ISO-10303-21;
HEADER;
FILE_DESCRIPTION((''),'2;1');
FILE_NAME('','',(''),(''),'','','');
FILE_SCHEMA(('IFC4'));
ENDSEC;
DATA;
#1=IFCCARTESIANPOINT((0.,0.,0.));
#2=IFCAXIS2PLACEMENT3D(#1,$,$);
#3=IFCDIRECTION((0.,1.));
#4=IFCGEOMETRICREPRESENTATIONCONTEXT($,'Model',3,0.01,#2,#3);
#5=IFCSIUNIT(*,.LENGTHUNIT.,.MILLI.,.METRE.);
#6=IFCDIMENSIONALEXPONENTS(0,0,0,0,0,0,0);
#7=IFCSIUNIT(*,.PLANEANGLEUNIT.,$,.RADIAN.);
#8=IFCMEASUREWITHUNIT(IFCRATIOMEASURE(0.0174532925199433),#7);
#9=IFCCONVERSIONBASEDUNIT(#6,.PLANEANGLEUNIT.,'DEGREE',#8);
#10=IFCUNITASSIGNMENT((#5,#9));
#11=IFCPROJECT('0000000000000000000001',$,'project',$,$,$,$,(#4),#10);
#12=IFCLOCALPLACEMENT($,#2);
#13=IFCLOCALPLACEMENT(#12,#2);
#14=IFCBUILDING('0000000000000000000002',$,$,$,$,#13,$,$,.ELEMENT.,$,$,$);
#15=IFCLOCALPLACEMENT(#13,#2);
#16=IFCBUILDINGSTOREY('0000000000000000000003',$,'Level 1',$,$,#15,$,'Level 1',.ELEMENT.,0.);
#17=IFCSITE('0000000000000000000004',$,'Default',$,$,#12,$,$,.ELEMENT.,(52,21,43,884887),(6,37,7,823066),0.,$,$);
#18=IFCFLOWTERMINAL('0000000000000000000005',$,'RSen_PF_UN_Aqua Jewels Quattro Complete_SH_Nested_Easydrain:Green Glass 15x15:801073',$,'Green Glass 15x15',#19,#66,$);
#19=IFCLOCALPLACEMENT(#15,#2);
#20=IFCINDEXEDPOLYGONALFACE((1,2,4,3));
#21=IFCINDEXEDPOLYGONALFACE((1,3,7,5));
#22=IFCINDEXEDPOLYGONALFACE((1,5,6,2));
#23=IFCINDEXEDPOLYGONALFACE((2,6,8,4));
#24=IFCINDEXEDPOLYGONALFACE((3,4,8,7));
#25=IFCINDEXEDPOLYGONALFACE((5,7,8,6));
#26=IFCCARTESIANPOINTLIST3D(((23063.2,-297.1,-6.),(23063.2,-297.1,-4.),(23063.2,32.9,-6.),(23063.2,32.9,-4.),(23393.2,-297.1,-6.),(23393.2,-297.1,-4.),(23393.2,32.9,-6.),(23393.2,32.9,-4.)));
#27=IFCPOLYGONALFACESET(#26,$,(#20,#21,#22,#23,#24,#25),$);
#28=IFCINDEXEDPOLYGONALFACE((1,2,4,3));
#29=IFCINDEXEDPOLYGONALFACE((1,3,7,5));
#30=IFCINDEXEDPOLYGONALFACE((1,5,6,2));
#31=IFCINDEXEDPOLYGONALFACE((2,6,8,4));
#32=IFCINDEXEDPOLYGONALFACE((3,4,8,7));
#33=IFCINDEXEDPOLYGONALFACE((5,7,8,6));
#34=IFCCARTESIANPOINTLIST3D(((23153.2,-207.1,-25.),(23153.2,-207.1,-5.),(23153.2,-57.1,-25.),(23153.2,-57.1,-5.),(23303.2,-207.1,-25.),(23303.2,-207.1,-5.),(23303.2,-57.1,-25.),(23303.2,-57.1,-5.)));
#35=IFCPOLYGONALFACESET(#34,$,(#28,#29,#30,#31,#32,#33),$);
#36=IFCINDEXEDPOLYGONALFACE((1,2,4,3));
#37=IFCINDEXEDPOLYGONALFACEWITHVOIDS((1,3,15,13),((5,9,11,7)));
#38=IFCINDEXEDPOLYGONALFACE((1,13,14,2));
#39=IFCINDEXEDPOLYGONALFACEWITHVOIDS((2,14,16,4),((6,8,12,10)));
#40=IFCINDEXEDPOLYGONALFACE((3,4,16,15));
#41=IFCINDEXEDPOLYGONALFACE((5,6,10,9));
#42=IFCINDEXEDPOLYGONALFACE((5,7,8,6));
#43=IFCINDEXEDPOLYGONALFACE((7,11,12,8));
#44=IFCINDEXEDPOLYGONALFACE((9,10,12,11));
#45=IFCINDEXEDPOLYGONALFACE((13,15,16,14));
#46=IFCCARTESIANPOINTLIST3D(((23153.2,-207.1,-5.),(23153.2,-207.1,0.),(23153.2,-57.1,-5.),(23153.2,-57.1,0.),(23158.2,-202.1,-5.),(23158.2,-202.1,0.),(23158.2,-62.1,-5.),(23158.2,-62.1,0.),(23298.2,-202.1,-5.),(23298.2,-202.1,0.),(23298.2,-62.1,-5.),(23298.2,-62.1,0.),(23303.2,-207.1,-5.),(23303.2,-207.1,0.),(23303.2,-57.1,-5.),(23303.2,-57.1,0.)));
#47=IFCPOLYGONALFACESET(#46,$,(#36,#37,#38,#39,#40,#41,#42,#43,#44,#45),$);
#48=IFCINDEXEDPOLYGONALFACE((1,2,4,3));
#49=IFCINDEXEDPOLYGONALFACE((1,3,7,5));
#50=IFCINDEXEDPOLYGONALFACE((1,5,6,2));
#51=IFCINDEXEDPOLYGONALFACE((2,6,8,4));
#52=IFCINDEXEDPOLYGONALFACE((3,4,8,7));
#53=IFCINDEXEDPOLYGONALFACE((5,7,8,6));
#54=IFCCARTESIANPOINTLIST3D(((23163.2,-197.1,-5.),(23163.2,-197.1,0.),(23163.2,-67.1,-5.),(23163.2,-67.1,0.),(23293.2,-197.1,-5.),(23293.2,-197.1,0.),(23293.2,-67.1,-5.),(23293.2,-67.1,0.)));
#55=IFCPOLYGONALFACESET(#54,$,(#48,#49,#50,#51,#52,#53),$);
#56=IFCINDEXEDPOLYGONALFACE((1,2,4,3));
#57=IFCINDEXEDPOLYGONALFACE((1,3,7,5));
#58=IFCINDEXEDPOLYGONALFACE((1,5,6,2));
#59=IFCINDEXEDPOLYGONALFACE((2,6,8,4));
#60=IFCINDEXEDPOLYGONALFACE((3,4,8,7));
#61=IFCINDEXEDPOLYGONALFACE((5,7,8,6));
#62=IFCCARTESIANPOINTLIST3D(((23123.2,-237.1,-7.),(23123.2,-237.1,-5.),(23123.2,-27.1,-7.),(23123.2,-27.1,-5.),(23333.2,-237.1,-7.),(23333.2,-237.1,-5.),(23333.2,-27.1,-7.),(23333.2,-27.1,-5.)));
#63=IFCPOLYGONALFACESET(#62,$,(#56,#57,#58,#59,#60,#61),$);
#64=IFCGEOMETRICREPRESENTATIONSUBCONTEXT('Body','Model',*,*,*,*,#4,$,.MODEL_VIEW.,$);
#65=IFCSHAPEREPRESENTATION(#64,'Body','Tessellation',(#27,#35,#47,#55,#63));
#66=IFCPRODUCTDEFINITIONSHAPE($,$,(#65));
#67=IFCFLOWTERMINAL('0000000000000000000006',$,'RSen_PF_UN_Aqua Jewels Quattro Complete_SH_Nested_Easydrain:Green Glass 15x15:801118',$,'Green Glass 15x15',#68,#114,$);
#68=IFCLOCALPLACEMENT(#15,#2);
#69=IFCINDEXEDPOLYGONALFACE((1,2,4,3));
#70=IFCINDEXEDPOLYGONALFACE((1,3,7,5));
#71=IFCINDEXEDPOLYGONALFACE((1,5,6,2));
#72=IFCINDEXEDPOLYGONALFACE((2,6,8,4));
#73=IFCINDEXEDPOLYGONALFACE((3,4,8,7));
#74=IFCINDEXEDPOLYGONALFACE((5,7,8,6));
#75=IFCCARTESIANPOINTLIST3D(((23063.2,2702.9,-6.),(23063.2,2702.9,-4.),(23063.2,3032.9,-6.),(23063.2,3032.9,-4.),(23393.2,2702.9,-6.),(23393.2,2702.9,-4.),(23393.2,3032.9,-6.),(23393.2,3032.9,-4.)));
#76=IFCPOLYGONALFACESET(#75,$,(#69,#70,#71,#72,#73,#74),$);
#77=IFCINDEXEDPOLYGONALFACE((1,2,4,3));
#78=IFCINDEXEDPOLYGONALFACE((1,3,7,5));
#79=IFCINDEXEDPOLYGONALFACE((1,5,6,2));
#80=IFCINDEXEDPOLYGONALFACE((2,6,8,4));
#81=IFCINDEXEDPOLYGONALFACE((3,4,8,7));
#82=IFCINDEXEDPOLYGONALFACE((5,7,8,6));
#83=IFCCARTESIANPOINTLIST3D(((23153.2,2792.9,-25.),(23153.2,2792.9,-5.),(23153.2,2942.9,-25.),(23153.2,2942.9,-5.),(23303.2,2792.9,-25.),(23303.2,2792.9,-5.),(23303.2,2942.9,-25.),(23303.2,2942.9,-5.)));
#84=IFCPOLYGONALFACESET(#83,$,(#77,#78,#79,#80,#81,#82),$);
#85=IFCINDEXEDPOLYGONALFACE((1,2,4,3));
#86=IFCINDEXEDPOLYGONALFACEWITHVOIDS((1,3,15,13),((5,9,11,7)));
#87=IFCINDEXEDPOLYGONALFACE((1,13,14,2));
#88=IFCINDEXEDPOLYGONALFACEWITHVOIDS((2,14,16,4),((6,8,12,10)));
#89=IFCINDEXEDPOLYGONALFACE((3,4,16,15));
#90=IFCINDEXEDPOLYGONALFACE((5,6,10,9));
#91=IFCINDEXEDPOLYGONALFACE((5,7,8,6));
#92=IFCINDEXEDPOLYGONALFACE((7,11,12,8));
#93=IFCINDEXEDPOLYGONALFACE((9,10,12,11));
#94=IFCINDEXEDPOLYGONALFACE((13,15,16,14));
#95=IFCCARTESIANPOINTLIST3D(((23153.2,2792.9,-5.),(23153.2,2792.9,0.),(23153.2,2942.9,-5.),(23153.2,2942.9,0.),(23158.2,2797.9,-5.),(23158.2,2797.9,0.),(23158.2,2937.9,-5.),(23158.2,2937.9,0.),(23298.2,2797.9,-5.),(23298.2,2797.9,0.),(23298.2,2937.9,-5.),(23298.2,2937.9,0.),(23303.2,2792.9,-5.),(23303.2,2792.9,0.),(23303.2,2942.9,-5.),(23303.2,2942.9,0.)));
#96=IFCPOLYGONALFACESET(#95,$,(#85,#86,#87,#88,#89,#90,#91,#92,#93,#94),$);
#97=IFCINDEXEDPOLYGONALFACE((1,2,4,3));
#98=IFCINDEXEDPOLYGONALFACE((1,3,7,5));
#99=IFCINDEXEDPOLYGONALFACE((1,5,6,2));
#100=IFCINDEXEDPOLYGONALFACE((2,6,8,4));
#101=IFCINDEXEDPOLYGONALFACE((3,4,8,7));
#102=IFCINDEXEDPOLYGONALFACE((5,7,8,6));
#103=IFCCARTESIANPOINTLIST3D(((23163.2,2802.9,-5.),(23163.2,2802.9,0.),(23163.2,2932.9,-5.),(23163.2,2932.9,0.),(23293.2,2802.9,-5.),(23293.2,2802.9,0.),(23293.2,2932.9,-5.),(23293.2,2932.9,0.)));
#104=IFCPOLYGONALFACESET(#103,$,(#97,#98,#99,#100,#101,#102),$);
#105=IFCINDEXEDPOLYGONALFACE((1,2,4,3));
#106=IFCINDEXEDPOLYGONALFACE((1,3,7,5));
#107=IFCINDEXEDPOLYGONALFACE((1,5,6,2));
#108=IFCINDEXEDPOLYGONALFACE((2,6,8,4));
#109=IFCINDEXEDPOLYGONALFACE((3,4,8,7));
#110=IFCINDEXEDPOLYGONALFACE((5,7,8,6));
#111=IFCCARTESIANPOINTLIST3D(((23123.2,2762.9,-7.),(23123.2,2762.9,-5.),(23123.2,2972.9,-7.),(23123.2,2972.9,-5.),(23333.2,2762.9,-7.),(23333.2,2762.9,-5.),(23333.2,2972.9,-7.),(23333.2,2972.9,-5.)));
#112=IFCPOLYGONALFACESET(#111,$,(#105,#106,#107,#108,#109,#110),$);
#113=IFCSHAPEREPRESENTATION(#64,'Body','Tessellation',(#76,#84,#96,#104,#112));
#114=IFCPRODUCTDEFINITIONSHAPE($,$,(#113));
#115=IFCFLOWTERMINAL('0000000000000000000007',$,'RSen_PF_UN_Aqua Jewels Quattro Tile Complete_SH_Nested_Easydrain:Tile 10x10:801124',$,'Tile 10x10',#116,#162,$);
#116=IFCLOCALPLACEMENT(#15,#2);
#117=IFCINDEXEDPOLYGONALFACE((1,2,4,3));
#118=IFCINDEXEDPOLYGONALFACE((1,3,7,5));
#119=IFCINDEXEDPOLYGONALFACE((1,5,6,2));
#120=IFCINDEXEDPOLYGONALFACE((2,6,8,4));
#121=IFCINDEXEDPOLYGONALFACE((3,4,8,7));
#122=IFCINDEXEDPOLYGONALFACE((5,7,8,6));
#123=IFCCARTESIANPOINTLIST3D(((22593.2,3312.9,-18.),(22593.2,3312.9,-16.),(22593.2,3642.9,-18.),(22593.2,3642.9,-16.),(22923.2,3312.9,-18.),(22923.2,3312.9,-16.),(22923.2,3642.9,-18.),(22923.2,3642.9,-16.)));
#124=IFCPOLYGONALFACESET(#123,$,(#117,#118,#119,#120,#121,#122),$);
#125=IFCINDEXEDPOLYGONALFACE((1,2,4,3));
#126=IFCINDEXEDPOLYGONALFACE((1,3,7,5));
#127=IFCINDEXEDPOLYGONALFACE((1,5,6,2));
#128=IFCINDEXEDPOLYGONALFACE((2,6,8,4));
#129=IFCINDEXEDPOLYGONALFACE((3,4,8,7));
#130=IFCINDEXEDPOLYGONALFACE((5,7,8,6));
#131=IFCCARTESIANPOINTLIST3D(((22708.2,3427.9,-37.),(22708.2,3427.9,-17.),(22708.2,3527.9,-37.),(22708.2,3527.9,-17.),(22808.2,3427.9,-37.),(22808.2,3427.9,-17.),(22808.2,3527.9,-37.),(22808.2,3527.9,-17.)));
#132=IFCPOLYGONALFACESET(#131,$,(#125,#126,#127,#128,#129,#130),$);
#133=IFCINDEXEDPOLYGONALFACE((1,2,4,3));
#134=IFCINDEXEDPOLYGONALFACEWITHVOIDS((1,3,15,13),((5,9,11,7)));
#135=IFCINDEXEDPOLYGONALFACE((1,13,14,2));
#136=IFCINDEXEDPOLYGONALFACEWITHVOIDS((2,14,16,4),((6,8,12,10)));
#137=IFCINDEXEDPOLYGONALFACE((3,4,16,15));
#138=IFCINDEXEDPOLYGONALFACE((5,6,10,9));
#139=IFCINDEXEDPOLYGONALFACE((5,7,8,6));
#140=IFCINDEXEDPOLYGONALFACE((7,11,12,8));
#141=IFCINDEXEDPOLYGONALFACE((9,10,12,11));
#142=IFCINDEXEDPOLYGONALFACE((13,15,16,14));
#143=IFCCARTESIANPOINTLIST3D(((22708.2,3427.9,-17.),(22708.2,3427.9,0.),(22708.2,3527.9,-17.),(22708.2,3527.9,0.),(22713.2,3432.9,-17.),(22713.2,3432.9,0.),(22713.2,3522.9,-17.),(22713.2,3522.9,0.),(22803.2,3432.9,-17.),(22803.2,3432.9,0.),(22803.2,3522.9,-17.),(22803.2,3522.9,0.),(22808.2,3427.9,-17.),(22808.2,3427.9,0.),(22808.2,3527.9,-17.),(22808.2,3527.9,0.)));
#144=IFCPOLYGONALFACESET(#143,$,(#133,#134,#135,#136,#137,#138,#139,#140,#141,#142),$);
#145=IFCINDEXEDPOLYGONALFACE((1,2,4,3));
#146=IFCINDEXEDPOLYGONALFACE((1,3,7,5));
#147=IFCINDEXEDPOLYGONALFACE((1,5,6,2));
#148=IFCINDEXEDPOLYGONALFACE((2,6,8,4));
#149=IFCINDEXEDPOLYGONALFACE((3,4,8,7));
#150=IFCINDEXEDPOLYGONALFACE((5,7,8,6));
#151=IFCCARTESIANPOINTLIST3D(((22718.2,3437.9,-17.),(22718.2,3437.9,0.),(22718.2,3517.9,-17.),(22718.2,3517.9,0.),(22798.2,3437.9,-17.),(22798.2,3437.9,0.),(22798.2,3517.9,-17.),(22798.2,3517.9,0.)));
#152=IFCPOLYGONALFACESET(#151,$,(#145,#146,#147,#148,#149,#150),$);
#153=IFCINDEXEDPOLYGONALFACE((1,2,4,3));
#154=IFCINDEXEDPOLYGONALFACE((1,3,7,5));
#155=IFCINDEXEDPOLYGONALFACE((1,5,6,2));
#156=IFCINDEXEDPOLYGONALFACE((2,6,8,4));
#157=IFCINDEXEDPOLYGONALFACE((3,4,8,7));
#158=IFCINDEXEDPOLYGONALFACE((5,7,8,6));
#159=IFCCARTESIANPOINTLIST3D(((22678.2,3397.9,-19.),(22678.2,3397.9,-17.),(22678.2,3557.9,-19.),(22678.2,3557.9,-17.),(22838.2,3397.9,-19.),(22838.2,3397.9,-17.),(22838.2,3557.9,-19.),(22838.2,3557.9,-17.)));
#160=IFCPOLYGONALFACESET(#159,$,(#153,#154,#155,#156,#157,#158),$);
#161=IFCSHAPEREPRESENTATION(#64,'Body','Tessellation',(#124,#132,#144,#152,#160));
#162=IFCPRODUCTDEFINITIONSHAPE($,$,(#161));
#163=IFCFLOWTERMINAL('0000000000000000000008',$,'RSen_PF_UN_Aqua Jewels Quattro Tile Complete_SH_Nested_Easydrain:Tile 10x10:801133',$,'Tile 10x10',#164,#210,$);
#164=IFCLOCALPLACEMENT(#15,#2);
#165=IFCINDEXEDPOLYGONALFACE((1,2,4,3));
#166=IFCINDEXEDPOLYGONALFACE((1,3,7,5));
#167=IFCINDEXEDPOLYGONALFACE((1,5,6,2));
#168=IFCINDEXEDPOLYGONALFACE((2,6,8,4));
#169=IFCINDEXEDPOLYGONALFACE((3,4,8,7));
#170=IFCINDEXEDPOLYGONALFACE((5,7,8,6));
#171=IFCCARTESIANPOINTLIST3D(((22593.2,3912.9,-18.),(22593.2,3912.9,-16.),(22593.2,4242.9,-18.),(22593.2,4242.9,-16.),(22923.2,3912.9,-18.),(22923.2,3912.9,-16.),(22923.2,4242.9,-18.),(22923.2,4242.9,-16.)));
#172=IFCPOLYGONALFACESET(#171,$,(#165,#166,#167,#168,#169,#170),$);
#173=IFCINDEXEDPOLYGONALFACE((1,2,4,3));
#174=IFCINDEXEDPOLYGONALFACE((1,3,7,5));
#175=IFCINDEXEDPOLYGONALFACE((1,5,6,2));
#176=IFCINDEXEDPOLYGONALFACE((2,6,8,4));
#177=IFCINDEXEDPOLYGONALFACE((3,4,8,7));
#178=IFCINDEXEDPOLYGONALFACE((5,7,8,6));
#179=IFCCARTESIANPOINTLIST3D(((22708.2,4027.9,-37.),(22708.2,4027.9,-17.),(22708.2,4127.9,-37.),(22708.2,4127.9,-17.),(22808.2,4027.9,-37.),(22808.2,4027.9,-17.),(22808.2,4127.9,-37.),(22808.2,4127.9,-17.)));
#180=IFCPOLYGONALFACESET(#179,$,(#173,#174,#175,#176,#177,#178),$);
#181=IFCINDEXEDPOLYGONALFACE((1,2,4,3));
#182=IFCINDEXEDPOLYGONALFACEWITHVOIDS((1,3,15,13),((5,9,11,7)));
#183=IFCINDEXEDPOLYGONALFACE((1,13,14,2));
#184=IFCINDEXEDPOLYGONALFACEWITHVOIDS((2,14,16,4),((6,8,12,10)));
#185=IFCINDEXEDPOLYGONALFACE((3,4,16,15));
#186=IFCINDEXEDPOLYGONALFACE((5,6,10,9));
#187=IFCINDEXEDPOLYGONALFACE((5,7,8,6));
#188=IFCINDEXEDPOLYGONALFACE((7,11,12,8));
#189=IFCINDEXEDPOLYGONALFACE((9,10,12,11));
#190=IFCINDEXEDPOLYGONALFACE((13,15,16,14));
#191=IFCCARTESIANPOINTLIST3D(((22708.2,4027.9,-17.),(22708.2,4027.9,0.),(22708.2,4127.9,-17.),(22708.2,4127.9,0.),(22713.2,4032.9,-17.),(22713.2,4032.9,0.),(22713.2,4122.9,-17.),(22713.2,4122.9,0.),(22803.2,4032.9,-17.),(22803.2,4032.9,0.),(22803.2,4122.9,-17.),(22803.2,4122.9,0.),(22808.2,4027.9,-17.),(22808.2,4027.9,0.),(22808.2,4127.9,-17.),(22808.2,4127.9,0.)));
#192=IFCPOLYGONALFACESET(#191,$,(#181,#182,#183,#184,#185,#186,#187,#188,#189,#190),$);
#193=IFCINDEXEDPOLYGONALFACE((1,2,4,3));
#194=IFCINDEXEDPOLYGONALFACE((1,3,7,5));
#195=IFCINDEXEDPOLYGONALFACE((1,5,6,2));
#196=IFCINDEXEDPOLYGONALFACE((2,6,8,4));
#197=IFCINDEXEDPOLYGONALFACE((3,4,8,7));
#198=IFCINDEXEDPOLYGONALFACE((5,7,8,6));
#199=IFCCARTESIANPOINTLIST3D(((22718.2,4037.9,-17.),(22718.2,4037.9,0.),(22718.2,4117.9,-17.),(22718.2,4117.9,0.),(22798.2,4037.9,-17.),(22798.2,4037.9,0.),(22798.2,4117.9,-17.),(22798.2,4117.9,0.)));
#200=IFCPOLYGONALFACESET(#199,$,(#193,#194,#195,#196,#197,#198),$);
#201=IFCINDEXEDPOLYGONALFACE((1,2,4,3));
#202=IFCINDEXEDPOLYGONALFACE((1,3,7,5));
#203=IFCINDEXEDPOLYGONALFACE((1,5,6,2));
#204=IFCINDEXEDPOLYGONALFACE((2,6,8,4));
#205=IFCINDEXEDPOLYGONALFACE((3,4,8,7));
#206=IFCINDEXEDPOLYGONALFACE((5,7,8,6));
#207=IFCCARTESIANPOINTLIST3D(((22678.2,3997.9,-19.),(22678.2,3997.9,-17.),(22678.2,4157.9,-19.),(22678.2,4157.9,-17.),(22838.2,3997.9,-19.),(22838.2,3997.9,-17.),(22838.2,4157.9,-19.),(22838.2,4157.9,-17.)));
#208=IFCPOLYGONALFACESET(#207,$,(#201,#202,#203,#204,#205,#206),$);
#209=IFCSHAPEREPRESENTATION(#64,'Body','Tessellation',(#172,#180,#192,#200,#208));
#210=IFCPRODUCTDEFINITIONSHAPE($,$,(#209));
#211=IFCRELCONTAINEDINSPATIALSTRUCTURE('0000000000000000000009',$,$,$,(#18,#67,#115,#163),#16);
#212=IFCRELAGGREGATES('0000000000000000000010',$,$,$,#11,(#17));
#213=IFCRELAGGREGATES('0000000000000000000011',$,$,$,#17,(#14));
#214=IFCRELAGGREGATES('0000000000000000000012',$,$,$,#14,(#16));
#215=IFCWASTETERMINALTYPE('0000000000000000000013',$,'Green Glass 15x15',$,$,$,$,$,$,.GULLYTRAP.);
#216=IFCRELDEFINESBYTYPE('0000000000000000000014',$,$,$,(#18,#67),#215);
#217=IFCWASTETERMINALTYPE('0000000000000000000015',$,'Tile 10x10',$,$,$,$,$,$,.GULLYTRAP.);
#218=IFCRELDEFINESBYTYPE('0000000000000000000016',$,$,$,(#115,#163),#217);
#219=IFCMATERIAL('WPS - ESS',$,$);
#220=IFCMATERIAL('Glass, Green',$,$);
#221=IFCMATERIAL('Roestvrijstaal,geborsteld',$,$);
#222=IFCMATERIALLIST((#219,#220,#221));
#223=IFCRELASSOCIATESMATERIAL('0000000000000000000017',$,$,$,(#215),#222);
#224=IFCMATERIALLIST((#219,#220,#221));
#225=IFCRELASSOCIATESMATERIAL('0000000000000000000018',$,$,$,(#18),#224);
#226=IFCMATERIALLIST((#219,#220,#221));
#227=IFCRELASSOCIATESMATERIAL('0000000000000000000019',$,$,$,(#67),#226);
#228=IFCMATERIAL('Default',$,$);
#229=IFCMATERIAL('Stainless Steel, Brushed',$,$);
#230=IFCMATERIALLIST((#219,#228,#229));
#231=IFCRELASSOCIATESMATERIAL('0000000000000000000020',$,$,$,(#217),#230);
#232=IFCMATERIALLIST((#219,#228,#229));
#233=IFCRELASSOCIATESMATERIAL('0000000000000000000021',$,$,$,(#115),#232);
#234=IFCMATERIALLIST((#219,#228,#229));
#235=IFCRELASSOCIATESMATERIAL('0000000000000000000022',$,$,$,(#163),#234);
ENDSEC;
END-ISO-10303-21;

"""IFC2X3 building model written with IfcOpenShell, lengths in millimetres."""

from ifc_helpers import new_model, entity, si_unit, converted_unit, direction, frame, frame_2d, origin, origin_2d_with_axis, place, context, subcontext, project, spatial, polyline, rectangle, outline, extrude, source, transform, mapped, material, material_list, type_object, type_shapes, element, save


model = new_model("IFC2X3")

# Units and contexts
model_context = context("Model", 3, precision=0.01, world=origin(), true_north=direction((0.0, 1.0)))
body_context = subcontext(model_context, "Body", "Model", "MODEL_VIEW")
ifc_project = project(units=[si_unit("LENGTHUNIT", "METRE", prefix="MILLI"), converted_unit("PLANEANGLEUNIT", "DEGREE", entity("IfcRatioMeasure", 0.0174532925199433), si_unit("PLANEANGLEUNIT", "RADIAN"), dimensions=[0, 0, 0, 0, 0, 0, 0])], contexts=[model_context])

# Site, building, storey
site_placement = place(None, origin())
site = spatial("IfcSite", under=ifc_project, at=site_placement, Name="Default", CompositionType="ELEMENT", RefLatitude=(52, 21, 43, 884887), RefLongitude=(6, 37, 7, 823066), RefElevation=0.0)
building_placement = place(site_placement, origin())
building = spatial("IfcBuilding", under=site, at=building_placement, CompositionType="ELEMENT")
storey_placement = place(building_placement, origin())
storey = spatial("IfcBuildingStorey", under=building, at=storey_placement, Name="Level 1", LongName="Level 1", CompositionType="ELEMENT", Elevation=0.0)

# Flow terminals
ifc_material_1 = material(Name="WPS - ESS")
ifc_material_2 = material(Name="Stainless Steel, Brushed")
ifc_material_3 = material(Name="Roestvrijstaal,geborsteld")
ifc_material_4 = material(Name="Glass, Green")
ifc_material_list_1 = material_list([ifc_material_1, ifc_material_4, ifc_material_3])
ifc_material_list_2 = material_list([ifc_material_1, ifc_material_4, ifc_material_3])
waste_terminal_type_1 = type_object("IfcWasteTerminalType", Name="Green Glass 15x15", PredefinedType="GULLYTRAP", material=ifc_material_list_2)
shared_shape_1 = source(origin(), body_context, "Body", "SweptSolid", [
    extrude(rectangle(XDim=330.0, YDim=330.0, at=origin_2d_with_axis()), frame((5.0, -10.0, -6.0), z_axis=(0.0, 0.0, 1.0), x_axis=(-1.0, 0.0, 0.0)), (0.0, 0.0, 1.0), 2.0),
    extrude(rectangle(XDim=150.0, YDim=150.0, at=origin_2d_with_axis()), frame((5.0, -10.0, -25.0), z_axis=(0.0, 0.0, 1.0), x_axis=(-1.0, 0.0, 0.0)), (0.0, 0.0, 1.0), 20.0),
    extrude(outline(polyline([(-75.0, -75.0), (75.0, -75.0), (75.0, 75.0), (-75.0, 75.0), (-75.0, -75.0)]), holes=[polyline([(-70.0, -70.0), (-70.0, 70.0), (70.0, 70.0), (70.0, -70.0), (-70.0, -70.0)])]), frame((5.0, -10.0, -5.0), z_axis=(0.0, 0.0, 1.0), x_axis=(-1.0, 0.0, 0.0)), (0.0, 0.0, 1.0), 5.0),
    extrude(rectangle(XDim=130.0, YDim=130.0, at=frame_2d((0.0, 0.0), x_axis=(1.0, 0.0))), frame((5.0, -10.0, -5.0), z_axis=(0.0, 0.0, 1.0), x_axis=(-1.0, 0.0, 0.0)), (0.0, 0.0, 1.0), 5.0),
    extrude(rectangle(XDim=210.0, YDim=210.0, at=origin_2d_with_axis()), frame((5.0, -10.0, -7.0), z_axis=(0.0, 0.0, 1.0), x_axis=(-1.0, 0.0, 0.0)), (0.0, 0.0, 1.0), 2.0),
])
type_shapes(waste_terminal_type_1, [shared_shape_1])
flow_terminal_1_placement = place(storey_placement, frame((23223.2, -122.1, 0.0)))
element("IfcFlowTerminal", 1, at=flow_terminal_1_placement, inside=storey, type_object=waste_terminal_type_1, material=ifc_material_list_1, Name="RSen_PF_UN_Aqua Jewels Quattro Complete_SH_Nested_Easydrain:Green Glass 15x15:801073", ObjectType="Green Glass 15x15", context=body_context, shape_type="MappedRepresentation", body=[
    mapped(shared_shape_1, transform((0.0, 0.0, 0.0), scale=1.0)),
])
ifc_material_list_3 = material_list([ifc_material_1, ifc_material_4, ifc_material_3])
flow_terminal_2_placement = place(storey_placement, frame((23223.2, 2877.9, 0.0)))
element("IfcFlowTerminal", 2, at=flow_terminal_2_placement, inside=storey, type_object=waste_terminal_type_1, material=ifc_material_list_3, Name="RSen_PF_UN_Aqua Jewels Quattro Complete_SH_Nested_Easydrain:Green Glass 15x15:801118", ObjectType="Green Glass 15x15", context=body_context, shape_type="MappedRepresentation", body=[
    mapped(shared_shape_1, transform((0.0, 0.0, 0.0), scale=1.0)),
])
ifc_material_5 = material(Name="Default")
ifc_material_list_4 = material_list([ifc_material_1, ifc_material_5, ifc_material_2])
ifc_material_list_5 = material_list([ifc_material_1, ifc_material_5, ifc_material_2])
waste_terminal_type_2 = type_object("IfcWasteTerminalType", Name="Tile 10x10", PredefinedType="GULLYTRAP", material=ifc_material_list_5)
shared_shape_2 = source(origin(), body_context, "Body", "SweptSolid", [
    extrude(rectangle(XDim=330.0, YDim=330.0, at=origin_2d_with_axis()), frame((0.0, 0.0, -18.0), z_axis=(0.0, 0.0, 1.0), x_axis=(-1.0, 0.0, 0.0)), (0.0, 0.0, 1.0), 2.0),
    extrude(rectangle(XDim=100.0, YDim=100.0, at=origin_2d_with_axis()), frame((0.0, 0.0, -37.0), z_axis=(0.0, 0.0, 1.0), x_axis=(-1.0, 0.0, 0.0)), (0.0, 0.0, 1.0), 20.0),
    extrude(outline(polyline([(-50.0, -50.0), (50.0, -50.0), (50.0, 50.0), (-50.0, 50.0), (-50.0, -50.0)]), holes=[polyline([(-45.0, -45.0), (-45.0, 45.0), (45.0, 45.0), (45.0, -45.0), (-45.0, -45.0)])]), frame((0.0, 0.0, -17.0), z_axis=(0.0, 0.0, 1.0), x_axis=(-1.0, 0.0, 0.0)), (0.0, 0.0, 1.0), 17.0),
    extrude(rectangle(XDim=80.0, YDim=80.0, at=origin_2d_with_axis()), frame((0.0, 0.0, -17.0), z_axis=(0.0, 0.0, 1.0), x_axis=(-1.0, 0.0, 0.0)), (0.0, 0.0, 1.0), 17.0),
    extrude(rectangle(XDim=160.0, YDim=160.0, at=origin_2d_with_axis()), frame((0.0, 0.0, -19.0), z_axis=(0.0, 0.0, 1.0), x_axis=(-1.0, 0.0, 0.0)), (0.0, 0.0, 1.0), 2.0),
])
type_shapes(waste_terminal_type_2, [shared_shape_2])
flow_terminal_3_placement = place(storey_placement, frame((22758.2, 3477.9, 0.0)))
element("IfcFlowTerminal", 3, at=flow_terminal_3_placement, inside=storey, type_object=waste_terminal_type_2, material=ifc_material_list_4, Name="RSen_PF_UN_Aqua Jewels Quattro Tile Complete_SH_Nested_Easydrain:Tile 10x10:801124", ObjectType="Tile 10x10", context=body_context, shape_type="MappedRepresentation", body=[
    mapped(shared_shape_2, transform((0.0, 0.0, 0.0), scale=1.0)),
])
ifc_material_list_6 = material_list([ifc_material_1, ifc_material_5, ifc_material_2])
flow_terminal_4_placement = place(storey_placement, frame((22758.2, 4077.9, 0.0)))
element("IfcFlowTerminal", 4, at=flow_terminal_4_placement, inside=storey, type_object=waste_terminal_type_2, material=ifc_material_list_6, Name="RSen_PF_UN_Aqua Jewels Quattro Tile Complete_SH_Nested_Easydrain:Tile 10x10:801133", ObjectType="Tile 10x10", context=body_context, shape_type="MappedRepresentation", body=[
    mapped(shared_shape_2, transform((0.0, 0.0, 0.0), scale=1.0)),
])

save(model, "model.ifc")
